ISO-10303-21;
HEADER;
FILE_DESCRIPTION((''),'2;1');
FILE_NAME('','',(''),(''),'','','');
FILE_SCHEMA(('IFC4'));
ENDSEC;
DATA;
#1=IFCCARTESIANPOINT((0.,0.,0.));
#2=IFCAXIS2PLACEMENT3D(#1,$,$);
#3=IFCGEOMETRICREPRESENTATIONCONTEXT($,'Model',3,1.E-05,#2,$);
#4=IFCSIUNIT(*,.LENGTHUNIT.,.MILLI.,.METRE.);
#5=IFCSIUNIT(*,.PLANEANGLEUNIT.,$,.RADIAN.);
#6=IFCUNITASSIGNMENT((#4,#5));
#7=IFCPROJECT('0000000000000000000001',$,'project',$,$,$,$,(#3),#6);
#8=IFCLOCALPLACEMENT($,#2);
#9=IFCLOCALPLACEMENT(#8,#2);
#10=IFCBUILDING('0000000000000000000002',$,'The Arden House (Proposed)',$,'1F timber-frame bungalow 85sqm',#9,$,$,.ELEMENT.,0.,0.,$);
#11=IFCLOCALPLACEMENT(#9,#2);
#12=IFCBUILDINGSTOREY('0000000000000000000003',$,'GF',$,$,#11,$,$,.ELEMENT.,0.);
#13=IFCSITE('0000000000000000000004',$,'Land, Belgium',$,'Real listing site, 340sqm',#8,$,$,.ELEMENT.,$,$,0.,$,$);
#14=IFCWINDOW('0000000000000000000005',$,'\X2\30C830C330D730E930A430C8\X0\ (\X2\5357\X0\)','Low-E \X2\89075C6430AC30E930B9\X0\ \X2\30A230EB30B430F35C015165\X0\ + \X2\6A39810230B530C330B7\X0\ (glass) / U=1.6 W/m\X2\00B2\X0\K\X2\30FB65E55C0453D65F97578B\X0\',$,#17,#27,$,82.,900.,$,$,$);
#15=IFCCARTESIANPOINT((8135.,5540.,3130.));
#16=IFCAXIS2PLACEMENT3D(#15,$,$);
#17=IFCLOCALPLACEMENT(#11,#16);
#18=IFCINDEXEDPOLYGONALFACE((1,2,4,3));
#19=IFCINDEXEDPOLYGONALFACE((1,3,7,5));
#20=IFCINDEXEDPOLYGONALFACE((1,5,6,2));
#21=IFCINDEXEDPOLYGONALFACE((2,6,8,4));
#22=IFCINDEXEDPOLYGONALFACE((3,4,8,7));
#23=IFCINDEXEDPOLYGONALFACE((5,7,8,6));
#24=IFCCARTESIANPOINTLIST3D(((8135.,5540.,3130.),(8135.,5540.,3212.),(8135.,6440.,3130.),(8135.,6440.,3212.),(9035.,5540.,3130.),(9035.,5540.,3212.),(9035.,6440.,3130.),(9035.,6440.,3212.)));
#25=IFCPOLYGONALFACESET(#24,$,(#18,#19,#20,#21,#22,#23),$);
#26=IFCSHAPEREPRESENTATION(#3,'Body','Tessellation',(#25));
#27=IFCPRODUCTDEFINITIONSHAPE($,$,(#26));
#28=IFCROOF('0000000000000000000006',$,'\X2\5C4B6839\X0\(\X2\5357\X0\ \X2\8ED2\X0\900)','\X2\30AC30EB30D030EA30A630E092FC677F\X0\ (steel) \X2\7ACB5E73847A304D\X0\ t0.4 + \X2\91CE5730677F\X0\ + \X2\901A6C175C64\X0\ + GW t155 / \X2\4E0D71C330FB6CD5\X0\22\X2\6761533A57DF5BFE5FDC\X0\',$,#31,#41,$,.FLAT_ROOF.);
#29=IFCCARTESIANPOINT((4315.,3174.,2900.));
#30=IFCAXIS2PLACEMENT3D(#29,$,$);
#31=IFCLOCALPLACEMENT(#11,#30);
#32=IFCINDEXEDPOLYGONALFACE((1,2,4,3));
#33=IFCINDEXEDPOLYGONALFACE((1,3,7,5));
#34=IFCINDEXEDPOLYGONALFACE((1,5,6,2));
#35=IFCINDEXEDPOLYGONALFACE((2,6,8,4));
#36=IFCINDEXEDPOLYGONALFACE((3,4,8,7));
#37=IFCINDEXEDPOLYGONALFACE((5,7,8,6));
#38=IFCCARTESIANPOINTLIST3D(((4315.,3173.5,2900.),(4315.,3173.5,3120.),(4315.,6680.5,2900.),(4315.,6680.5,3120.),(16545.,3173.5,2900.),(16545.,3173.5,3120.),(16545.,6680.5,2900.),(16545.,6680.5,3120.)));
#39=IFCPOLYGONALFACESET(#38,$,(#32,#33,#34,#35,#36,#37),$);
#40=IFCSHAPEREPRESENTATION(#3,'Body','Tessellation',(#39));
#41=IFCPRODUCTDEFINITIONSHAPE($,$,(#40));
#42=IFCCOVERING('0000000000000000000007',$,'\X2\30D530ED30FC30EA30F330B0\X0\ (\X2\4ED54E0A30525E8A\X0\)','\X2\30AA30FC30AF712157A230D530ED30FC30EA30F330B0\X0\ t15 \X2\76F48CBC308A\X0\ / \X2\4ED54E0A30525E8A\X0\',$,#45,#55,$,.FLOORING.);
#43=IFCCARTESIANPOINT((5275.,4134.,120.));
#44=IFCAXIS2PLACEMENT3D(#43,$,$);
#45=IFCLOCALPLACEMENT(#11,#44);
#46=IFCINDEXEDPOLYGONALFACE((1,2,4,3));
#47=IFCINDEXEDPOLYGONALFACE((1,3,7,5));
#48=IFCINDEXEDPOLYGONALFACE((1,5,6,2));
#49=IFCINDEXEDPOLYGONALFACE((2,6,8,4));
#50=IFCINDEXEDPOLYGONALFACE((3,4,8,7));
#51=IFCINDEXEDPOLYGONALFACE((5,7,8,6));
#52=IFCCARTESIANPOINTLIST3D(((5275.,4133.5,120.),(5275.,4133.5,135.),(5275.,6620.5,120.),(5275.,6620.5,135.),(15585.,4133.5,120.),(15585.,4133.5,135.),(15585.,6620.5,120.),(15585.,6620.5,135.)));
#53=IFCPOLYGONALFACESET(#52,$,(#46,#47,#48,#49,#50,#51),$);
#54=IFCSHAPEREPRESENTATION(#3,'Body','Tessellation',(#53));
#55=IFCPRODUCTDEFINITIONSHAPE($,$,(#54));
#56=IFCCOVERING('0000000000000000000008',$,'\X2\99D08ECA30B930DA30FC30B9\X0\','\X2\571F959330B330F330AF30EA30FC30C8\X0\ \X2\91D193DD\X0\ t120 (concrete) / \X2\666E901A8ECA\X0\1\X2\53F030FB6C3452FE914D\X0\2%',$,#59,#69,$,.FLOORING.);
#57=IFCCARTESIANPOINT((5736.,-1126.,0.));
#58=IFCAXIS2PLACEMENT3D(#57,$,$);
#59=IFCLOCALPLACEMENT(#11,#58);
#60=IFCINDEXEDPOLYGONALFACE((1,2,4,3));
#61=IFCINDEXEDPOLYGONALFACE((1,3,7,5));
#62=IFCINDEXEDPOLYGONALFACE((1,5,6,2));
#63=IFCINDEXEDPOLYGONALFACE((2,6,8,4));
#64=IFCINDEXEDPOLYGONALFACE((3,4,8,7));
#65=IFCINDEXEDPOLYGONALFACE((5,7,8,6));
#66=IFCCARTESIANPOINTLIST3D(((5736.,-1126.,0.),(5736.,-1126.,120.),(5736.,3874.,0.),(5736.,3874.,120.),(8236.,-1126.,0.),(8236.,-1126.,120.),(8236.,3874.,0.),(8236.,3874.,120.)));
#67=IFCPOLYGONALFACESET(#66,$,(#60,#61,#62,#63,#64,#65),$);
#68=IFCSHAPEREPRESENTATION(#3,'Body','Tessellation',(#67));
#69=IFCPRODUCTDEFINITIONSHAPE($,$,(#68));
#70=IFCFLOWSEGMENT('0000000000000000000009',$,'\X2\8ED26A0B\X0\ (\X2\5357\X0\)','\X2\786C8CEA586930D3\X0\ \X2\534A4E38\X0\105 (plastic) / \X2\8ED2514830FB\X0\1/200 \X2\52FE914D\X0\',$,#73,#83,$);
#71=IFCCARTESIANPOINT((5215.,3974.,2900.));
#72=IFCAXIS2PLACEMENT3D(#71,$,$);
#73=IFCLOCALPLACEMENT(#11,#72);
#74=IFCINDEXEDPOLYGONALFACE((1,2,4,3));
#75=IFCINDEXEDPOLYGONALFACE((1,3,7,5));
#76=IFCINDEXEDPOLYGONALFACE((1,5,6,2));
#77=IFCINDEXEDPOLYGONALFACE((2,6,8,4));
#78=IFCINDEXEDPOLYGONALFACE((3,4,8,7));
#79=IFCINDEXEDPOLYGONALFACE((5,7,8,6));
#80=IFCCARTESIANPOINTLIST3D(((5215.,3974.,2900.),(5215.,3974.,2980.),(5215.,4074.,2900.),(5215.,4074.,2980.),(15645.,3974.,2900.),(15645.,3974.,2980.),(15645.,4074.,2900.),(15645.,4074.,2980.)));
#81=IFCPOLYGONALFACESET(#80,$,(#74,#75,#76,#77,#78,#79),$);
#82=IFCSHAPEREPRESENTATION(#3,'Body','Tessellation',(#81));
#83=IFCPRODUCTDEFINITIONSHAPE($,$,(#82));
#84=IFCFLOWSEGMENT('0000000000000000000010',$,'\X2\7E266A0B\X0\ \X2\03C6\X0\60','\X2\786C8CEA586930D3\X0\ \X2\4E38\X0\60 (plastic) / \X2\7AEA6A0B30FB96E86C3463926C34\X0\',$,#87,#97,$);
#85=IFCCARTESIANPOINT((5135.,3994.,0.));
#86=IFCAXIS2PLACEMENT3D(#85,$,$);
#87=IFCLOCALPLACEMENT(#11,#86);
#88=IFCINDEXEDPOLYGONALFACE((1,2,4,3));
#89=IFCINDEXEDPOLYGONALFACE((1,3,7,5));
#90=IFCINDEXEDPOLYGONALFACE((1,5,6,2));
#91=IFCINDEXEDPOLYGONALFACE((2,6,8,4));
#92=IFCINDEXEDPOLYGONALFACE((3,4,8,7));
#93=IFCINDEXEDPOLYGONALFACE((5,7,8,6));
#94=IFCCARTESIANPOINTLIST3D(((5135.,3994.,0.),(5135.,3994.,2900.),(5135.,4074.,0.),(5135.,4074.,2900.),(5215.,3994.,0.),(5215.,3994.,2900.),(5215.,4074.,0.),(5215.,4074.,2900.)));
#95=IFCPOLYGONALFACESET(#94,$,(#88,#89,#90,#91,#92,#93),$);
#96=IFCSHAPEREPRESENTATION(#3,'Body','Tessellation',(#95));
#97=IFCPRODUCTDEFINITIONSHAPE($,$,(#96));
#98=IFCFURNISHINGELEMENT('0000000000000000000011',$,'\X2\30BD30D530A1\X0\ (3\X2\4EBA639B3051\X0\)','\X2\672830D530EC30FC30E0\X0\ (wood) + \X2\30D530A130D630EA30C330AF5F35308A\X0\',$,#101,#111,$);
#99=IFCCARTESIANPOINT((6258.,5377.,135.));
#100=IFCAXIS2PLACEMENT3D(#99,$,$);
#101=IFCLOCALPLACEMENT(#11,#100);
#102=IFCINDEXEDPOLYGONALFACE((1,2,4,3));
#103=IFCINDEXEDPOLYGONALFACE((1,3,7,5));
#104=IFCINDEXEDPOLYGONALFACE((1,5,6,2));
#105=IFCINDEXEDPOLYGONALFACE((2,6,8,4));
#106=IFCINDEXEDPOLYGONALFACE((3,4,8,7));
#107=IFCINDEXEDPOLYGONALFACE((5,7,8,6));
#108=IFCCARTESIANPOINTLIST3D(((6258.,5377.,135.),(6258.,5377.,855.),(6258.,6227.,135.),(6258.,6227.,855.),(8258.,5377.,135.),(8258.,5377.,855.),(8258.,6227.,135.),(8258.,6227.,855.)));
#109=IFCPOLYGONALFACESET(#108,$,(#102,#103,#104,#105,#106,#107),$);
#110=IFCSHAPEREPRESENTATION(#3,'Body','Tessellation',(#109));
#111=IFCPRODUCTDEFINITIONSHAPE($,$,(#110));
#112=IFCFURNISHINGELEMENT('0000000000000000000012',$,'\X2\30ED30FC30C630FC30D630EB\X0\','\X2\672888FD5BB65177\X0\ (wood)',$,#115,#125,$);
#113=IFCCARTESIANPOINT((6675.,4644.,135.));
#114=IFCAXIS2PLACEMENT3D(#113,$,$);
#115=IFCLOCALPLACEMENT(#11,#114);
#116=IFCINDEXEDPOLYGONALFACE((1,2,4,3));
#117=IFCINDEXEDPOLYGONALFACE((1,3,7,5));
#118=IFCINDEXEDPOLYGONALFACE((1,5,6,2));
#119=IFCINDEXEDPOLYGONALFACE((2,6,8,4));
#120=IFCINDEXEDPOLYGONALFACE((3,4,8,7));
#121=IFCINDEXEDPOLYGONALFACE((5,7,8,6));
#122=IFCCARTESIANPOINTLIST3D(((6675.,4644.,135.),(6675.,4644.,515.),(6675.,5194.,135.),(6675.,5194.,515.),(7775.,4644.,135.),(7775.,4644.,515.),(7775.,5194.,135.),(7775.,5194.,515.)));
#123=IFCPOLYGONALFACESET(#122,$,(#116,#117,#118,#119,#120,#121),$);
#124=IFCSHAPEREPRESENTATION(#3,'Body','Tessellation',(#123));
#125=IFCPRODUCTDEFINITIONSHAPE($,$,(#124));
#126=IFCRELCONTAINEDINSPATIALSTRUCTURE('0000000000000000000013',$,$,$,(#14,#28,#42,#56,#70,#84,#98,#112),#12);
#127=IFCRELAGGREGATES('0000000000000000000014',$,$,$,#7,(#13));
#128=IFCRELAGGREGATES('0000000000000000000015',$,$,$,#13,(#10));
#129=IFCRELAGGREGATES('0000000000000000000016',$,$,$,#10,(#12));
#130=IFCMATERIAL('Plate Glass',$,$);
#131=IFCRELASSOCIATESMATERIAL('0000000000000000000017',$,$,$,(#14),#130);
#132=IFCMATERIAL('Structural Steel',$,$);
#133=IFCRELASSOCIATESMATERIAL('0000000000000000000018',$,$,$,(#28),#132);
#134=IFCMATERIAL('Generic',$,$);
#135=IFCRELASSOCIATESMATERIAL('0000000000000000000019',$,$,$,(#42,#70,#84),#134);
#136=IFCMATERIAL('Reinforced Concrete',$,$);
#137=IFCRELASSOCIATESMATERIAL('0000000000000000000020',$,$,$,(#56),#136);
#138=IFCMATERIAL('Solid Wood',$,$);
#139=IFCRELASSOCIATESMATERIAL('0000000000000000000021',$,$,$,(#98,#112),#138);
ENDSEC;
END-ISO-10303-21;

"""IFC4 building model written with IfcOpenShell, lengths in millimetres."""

from ifc_helpers import new_model, si_unit, frame, frame_2d, origin, place, context, project, spatial, rectangle, extrude, material, element, save


model = new_model("IFC4")

# Units and contexts
model_context = context("Model", 3, precision=1e-05, world=origin())
ifc_project = project(units=[si_unit("LENGTHUNIT", "METRE", prefix="MILLI"), si_unit("PLANEANGLEUNIT", "RADIAN")], contexts=[model_context])

# Site, building, storey
site_placement = place(None, origin())
site = spatial("IfcSite", under=ifc_project, at=site_placement, Name="Land, Belgium", ObjectType="Real listing site, 340sqm", CompositionType="ELEMENT", RefElevation=0.0)
building_placement = place(site_placement, origin())
building = spatial("IfcBuilding", under=site, at=building_placement, Name="The Arden House (Proposed)", ObjectType="1F timber-frame bungalow 85sqm", CompositionType="ELEMENT", ElevationOfRefHeight=0.0, ElevationOfTerrain=0.0)
storey_placement = place(building_placement, origin())
storey = spatial("IfcBuildingStorey", under=building, at=storey_placement, Name="GF", CompositionType="ELEMENT", Elevation=0.0)

# Shared definitions
ifc_material_1 = material(Name="Solid Wood")

# Shared definitions
ifc_material_2 = material(Name="Reinforced Concrete")

# Shared definitions
ifc_material_3 = material(Name="Plate Glass")

# Window
window_1_placement = place(storey_placement, frame((8135.0, 5540.0, 3130.0)))
element("IfcWindow", 1, at=window_1_placement, inside=storey, material=ifc_material_3, Name="トップライト (南)", Description="Low-E 複層ガラス アルゴン封入 + 樹脂サッシ (glass) / U=1.6 W/m²K・日射取得型", OverallHeight=82.0, OverallWidth=900.0, context=model_context, shape_type="SweptSolid", body=[
    extrude(rectangle(XDim=900.0, YDim=900.0, at=frame_2d((450.0, 450.0))), frame((8135.0, 5540.0, 3130.0)), (0.0, 0.0, 1.0), 82.0),
])

# Roof
ifc_material_4 = material(Name="Structural Steel")
roof_1_placement = place(storey_placement, frame((4315.0, 3174.0, 2900.0)))
element("IfcRoof", 2, at=roof_1_placement, inside=storey, material=ifc_material_4, Name="屋根(南 軒900)", Description="ガルバリウム鋼板 (steel) 立平葺き t0.4 + 野地板 + 通気層 + GW t155 / 不燃・法22条区域対応", PredefinedType="FLAT_ROOF", context=model_context, shape_type="SweptSolid", body=[
    extrude(rectangle(XDim=12230.0, YDim=3507.0, at=frame_2d((6115.0, 1753.0))), frame((4315.0, 3174.0, 2900.0)), (0.0, 0.0, 1.0), 220.0),
])

# Coverings
ifc_material_5 = material(Name="Generic")
covering_1_placement = place(storey_placement, frame((5275.0, 4134.0, 120.0)))
element("IfcCovering", 3, at=covering_1_placement, inside=storey, material=ifc_material_5, Name="フローリング (仕上げ床)", Description="オーク無垢フローリング t15 直貼り / 仕上げ床", PredefinedType="FLOORING", context=model_context, shape_type="SweptSolid", body=[
    extrude(rectangle(XDim=10310.0, YDim=2487.0, at=frame_2d((5155.0, 1243.0))), frame((5275.0, 4134.0, 120.0)), (0.0, 0.0, 1.0), 15.0),
])
covering_2_placement = place(storey_placement, frame((5736.0, -1126.0, 0.0)))
element("IfcCovering", 4, at=covering_2_placement, inside=storey, material=ifc_material_2, Name="駐車スペース", Description="土間コンクリート 金鏝 t120 (concrete) / 普通車1台・水勾配2%", PredefinedType="FLOORING", context=model_context, shape_type="SweptSolid", body=[
    extrude(rectangle(XDim=2500.0, YDim=5000.0, at=frame_2d((1250.0, 2500.0))), frame((5736.0, -1126.0, 0.0)), (0.0, 0.0, 1.0), 120.0),
])

# Flow segments
flow_segment_1_placement = place(storey_placement, frame((5215.0, 3974.0, 2900.0)))
element("IfcFlowSegment", 5, at=flow_segment_1_placement, inside=storey, material=ifc_material_5, Name="軒樋 (南)", Description="硬質塩ビ 半丸105 (plastic) / 軒先・1/200 勾配", context=model_context, shape_type="SweptSolid", body=[
    extrude(rectangle(XDim=10430.0, YDim=100.0, at=frame_2d((5215.0, 50.0))), frame((5215.0, 3974.0, 2900.0)), (0.0, 0.0, 1.0), 80.0),
])
flow_segment_2_placement = place(storey_placement, frame((5135.0, 3994.0, 0.0)))
element("IfcFlowSegment", 6, at=flow_segment_2_placement, inside=storey, material=ifc_material_5, Name="縦樋 φ60", Description="硬質塩ビ 丸60 (plastic) / 竪樋・雨水排水", context=model_context, shape_type="SweptSolid", body=[
    extrude(rectangle(XDim=80.0, YDim=80.0, at=frame_2d((40.0, 40.0))), frame((5135.0, 3994.0, 0.0)), (0.0, 0.0, 1.0), 2900.0),
])

# Furnishing elements
furnishing_1_placement = place(storey_placement, frame((6258.0, 5377.0, 135.0)))
element("IfcFurnishingElement", 7, at=furnishing_1_placement, inside=storey, material=ifc_material_1, Name="ソファ (3人掛け)", Description="木フレーム (wood) + ファブリック張り", context=model_context, shape_type="SweptSolid", body=[
    extrude(rectangle(XDim=2000.0, YDim=850.0, at=frame_2d((1000.0, 425.0))), frame((6258.0, 5377.0, 135.0)), (0.0, 0.0, 1.0), 720.0),
])
furnishing_2_placement = place(storey_placement, frame((6675.0, 4644.0, 135.0)))
element("IfcFurnishingElement", 8, at=furnishing_2_placement, inside=storey, material=ifc_material_1, Name="ローテーブル", Description="木製家具 (wood)", context=model_context, shape_type="SweptSolid", body=[
    extrude(rectangle(XDim=1100.0, YDim=550.0, at=frame_2d((550.0, 275.0))), frame((6675.0, 4644.0, 135.0)), (0.0, 0.0, 1.0), 380.0),
])

save(model, "model.ifc")
